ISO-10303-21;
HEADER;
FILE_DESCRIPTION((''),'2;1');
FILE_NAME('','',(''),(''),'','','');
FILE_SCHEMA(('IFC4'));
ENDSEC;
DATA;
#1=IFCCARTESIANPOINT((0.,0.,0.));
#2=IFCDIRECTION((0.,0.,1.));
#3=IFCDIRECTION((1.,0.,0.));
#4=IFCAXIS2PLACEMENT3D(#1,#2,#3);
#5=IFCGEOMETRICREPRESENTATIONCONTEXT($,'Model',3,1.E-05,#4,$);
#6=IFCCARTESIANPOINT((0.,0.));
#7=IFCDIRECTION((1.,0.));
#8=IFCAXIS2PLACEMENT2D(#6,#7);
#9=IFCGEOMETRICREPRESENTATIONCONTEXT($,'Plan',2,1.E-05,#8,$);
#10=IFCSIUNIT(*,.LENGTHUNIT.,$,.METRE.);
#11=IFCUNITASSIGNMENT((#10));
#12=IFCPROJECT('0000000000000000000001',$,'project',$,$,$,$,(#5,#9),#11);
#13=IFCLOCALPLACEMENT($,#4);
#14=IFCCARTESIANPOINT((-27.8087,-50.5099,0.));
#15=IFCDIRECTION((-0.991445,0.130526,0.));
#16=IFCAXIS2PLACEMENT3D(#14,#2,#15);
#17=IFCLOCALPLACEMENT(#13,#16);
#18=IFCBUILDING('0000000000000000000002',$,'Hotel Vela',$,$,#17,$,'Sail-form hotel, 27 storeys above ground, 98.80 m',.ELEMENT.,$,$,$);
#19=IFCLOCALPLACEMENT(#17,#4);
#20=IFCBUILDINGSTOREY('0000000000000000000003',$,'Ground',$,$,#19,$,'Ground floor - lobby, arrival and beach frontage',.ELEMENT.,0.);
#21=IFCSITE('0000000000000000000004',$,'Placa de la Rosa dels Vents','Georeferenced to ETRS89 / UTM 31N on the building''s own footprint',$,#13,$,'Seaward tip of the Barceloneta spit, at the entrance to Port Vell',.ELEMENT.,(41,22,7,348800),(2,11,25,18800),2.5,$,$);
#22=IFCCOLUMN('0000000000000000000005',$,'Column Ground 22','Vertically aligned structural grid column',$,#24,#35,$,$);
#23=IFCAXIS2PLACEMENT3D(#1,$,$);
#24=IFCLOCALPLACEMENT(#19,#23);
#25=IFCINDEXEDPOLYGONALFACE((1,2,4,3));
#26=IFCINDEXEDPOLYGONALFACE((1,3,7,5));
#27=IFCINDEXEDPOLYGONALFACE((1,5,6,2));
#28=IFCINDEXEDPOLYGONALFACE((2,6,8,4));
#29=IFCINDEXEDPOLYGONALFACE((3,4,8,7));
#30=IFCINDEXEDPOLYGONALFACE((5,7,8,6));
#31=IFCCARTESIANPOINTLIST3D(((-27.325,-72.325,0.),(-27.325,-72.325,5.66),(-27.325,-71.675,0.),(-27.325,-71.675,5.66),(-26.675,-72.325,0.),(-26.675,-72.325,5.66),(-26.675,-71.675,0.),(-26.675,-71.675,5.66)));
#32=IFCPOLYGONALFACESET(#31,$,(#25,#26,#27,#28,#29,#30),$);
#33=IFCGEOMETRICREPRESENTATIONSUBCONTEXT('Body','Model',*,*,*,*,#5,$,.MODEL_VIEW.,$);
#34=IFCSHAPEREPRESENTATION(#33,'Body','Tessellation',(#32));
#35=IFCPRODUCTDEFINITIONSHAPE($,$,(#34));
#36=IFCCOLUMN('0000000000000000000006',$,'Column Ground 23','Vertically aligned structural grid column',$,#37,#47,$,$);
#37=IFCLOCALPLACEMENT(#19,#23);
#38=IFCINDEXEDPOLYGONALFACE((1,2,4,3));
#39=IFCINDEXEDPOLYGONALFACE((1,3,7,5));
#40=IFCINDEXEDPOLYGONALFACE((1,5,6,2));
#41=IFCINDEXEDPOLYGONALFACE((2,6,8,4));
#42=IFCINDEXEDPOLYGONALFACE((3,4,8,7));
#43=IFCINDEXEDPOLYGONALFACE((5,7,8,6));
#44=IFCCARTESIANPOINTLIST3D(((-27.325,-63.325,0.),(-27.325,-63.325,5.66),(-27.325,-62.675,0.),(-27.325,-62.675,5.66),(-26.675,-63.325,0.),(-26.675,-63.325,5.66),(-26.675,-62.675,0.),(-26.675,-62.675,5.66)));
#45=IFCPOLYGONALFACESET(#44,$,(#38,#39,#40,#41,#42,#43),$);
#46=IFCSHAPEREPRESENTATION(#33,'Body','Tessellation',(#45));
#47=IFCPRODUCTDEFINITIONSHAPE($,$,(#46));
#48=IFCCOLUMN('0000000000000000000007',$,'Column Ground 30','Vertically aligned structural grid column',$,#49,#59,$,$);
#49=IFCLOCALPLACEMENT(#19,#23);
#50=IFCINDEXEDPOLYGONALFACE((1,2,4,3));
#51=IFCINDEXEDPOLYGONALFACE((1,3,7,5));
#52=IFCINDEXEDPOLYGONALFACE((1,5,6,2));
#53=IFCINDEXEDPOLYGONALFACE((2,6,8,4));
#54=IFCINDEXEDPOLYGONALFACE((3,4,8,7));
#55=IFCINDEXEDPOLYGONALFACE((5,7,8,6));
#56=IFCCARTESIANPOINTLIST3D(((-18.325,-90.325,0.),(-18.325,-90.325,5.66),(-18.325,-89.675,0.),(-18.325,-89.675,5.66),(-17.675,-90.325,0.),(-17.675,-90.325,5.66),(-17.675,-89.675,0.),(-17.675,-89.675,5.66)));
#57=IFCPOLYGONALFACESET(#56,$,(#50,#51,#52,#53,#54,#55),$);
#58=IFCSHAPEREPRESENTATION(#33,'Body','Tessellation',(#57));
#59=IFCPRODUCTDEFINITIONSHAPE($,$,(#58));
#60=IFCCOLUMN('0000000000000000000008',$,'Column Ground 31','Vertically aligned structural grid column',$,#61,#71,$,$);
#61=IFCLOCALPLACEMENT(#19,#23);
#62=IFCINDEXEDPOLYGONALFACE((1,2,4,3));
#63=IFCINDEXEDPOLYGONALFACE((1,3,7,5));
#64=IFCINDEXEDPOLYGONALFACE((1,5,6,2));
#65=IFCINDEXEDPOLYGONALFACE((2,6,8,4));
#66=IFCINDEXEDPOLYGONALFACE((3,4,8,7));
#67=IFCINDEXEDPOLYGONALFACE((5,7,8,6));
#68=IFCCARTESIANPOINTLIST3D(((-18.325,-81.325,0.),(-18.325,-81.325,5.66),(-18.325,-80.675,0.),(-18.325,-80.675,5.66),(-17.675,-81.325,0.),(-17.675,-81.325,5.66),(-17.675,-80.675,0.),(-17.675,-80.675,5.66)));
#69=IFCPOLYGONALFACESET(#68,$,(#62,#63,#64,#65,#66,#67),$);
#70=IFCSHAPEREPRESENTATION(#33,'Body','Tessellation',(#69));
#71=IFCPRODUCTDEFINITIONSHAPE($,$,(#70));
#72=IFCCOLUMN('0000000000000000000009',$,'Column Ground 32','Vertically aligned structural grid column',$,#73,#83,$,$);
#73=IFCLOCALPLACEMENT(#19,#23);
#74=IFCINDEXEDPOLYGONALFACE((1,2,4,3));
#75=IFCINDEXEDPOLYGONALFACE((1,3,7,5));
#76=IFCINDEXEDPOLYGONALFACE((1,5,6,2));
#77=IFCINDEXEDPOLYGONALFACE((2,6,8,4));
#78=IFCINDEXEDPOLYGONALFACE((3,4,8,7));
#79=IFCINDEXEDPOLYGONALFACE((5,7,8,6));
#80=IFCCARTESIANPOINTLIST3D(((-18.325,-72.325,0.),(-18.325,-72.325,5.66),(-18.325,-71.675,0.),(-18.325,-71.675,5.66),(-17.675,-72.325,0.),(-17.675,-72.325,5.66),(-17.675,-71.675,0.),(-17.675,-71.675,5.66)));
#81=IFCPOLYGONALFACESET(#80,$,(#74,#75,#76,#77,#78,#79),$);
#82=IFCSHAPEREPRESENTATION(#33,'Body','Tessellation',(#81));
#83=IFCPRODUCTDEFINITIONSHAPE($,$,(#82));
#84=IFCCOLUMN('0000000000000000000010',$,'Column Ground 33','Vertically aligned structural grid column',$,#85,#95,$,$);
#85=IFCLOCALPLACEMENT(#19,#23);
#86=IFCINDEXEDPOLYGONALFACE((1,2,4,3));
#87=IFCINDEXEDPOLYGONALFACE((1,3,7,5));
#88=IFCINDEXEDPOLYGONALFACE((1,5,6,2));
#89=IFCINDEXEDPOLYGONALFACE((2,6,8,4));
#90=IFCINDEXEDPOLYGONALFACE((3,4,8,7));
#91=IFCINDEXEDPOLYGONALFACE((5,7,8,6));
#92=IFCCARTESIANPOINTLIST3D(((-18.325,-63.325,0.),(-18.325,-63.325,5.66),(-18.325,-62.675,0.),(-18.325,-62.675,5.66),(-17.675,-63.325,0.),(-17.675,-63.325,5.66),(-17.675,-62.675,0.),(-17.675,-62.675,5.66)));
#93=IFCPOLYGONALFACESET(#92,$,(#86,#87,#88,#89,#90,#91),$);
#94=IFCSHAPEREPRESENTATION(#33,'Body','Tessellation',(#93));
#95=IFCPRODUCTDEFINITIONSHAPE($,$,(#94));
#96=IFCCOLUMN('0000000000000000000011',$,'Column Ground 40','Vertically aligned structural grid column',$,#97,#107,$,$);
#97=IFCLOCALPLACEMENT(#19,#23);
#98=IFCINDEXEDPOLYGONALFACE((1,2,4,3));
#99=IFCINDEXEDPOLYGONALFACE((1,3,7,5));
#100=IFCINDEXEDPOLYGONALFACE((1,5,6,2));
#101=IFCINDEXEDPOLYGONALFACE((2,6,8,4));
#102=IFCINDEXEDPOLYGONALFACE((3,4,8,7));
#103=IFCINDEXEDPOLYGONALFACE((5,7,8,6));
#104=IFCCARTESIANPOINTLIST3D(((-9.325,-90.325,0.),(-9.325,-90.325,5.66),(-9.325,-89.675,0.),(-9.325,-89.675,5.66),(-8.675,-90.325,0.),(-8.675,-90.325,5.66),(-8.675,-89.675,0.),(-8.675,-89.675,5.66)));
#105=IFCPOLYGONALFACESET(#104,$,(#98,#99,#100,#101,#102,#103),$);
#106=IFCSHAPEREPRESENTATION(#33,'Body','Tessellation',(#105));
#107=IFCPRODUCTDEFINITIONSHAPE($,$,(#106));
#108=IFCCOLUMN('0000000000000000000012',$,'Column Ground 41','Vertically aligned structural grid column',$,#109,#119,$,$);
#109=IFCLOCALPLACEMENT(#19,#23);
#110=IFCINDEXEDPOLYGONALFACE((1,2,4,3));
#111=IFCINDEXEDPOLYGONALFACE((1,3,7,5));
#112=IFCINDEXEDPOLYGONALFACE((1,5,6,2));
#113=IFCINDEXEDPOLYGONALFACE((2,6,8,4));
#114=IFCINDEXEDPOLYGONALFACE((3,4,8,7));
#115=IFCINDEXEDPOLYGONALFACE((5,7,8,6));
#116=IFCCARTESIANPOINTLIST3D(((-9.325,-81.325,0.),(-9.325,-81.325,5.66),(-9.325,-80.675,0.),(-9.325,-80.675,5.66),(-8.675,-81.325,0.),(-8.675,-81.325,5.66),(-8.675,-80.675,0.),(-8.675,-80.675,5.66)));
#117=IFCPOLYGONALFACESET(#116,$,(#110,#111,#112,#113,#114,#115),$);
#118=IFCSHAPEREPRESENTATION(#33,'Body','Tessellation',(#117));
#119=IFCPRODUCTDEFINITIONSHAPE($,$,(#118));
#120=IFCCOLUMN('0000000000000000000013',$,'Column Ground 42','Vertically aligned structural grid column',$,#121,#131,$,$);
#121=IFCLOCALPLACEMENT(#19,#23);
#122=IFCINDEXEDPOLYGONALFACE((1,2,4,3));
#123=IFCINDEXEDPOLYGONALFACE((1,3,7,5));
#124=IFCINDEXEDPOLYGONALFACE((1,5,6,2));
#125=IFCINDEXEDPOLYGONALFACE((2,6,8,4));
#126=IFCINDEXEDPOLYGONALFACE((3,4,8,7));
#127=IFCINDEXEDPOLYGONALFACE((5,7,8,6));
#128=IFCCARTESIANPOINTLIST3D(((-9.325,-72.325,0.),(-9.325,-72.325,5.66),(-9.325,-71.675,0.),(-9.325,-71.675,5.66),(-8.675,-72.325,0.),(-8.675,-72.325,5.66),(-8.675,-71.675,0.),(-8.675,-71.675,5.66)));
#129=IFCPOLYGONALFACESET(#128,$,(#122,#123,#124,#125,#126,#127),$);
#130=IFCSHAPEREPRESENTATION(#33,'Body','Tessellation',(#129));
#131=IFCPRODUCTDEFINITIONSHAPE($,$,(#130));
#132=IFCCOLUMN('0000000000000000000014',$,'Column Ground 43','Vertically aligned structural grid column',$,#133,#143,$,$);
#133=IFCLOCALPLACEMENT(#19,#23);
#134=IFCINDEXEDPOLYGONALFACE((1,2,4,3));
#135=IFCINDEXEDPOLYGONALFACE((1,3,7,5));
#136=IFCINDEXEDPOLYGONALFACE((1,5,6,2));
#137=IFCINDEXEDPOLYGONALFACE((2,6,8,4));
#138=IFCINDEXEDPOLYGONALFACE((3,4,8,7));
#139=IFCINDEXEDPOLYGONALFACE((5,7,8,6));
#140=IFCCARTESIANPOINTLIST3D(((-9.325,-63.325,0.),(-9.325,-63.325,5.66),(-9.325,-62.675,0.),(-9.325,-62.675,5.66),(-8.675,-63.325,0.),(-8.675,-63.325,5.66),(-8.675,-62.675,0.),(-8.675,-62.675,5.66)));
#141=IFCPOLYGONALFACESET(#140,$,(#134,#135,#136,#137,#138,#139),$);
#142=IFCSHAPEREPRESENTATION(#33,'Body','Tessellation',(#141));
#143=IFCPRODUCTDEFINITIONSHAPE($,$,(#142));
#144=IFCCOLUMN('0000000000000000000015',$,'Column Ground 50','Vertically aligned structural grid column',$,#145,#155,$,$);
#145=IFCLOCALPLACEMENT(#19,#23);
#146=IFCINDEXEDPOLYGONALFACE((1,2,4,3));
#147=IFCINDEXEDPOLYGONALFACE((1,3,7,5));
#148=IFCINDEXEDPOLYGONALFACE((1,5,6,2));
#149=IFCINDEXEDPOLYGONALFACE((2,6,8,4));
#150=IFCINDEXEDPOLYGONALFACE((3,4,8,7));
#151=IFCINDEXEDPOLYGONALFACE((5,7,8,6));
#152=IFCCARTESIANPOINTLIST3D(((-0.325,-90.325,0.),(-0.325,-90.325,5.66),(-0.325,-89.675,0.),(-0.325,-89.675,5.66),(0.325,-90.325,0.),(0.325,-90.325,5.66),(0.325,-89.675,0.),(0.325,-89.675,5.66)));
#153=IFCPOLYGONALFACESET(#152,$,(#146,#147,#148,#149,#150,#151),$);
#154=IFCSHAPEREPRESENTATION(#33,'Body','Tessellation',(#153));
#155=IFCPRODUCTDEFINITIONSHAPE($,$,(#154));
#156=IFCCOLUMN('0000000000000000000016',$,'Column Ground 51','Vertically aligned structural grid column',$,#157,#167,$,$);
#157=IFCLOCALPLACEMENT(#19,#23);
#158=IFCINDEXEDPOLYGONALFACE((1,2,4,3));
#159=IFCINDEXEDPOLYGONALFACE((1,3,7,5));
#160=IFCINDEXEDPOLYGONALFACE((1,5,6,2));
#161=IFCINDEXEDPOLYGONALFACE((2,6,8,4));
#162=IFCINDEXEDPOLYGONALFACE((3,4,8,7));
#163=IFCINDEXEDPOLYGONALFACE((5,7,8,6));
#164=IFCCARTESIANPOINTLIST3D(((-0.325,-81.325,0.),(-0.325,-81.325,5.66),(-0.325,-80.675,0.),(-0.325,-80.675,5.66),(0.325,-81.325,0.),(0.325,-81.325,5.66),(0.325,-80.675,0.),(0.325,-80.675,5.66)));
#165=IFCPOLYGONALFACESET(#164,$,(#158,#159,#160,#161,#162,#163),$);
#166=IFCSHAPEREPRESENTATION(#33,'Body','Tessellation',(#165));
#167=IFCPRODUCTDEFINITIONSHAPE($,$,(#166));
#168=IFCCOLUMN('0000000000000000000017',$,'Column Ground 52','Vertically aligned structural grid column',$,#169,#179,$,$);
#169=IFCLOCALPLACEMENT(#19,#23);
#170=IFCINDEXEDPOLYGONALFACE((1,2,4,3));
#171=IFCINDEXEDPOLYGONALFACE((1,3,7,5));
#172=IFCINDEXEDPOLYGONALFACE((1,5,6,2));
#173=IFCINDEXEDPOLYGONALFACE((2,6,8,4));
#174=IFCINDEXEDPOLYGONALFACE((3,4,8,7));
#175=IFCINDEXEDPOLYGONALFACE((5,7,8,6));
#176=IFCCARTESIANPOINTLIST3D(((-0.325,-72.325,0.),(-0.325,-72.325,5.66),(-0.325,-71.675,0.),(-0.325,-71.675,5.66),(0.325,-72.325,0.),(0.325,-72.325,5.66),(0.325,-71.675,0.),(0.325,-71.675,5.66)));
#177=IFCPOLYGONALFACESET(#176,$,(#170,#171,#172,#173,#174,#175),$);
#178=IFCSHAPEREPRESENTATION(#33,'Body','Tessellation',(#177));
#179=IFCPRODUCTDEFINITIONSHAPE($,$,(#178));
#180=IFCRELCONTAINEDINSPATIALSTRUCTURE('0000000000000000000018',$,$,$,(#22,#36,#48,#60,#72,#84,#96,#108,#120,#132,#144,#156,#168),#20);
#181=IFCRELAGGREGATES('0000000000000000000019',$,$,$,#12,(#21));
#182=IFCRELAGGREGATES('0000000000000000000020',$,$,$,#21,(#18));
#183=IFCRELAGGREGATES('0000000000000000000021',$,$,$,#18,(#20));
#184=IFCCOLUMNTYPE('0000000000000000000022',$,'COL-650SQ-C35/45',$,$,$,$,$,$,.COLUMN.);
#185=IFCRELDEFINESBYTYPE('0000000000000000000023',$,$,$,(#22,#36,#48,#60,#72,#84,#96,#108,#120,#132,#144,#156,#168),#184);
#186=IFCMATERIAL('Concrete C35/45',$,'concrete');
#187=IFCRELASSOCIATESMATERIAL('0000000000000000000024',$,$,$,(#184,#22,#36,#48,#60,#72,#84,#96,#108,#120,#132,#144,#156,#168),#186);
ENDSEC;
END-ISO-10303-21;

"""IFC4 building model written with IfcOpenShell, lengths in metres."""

from ifc_helpers import new_model, si_unit, frame, origin_with_axes, origin_2d_with_axis, place, context, subcontext, project, spatial, line, indexed_curve, rectangle, outline, extrude, material, material_profile, profile_set, profile_usage, type_object, element, save


model = new_model("IFC4")

# Units and contexts
model_context = context("Model", 3, precision=1e-05, world=origin_with_axes())
plan_context = context("Plan", 2, precision=1e-05, world=origin_2d_with_axis())
body_context = subcontext(model_context, "Body", "Model", "MODEL_VIEW")
ifc_project = project(units=[si_unit("LENGTHUNIT", "METRE")], contexts=[model_context, plan_context])

# Site, building, storey
site_placement = place(None, origin_with_axes())
site = spatial("IfcSite", under=ifc_project, at=site_placement, Name="Placa de la Rosa dels Vents", Description="Georeferenced to ETRS89 / UTM 31N on the building's own footprint", LongName="Seaward tip of the Barceloneta spit, at the entrance to Port Vell", CompositionType="ELEMENT", RefLatitude=(41, 22, 7, 348800), RefLongitude=(2, 11, 25, 18800), RefElevation=2.5)
building_placement = place(site_placement, frame((-27.8087, -50.5099, 0.0), z_axis=(0.0, 0.0, 1.0), x_axis=(-0.991445, 0.130526, 0.0)))
building = spatial("IfcBuilding", under=site, at=building_placement, Name="Hotel Vela", LongName="Sail-form hotel, 27 storeys above ground, 98.80 m", CompositionType="ELEMENT")
storey_placement = place(building_placement, origin_with_axes())
storey = spatial("IfcBuildingStorey", under=building, at=storey_placement, Name="Ground", LongName="Ground floor - lobby, arrival and beach frontage", CompositionType="ELEMENT", Elevation=0.0)

# Columns
ifc_material = material(Name="Concrete C35/45", Category="concrete")
ifc_material_profile = material_profile(ifc_material, rectangle(XDim=0.65, YDim=0.65))
ifc_profile_set = profile_set([ifc_material_profile], Name="COL-650SQ-C35/45")
column_type = type_object("IfcColumnType", Name="COL-650SQ-C35/45", PredefinedType="COLUMN", material=ifc_profile_set)
ifc_profile_usage_1 = profile_usage(ifc_profile_set)
column_1_placement = place(storey_placement, frame((-27.325, -72.325, 0.0), z_axis=(0.0, 0.0, 1.0), x_axis=(1.0, 0.0, 0.0)))
element("IfcColumn", 1, at=column_1_placement, inside=storey, type_object=column_type, material=ifc_profile_usage_1, Name="Column Ground 22", Description="Vertically aligned structural grid column", context=body_context, shape_type="SweptSolid", body=[
    extrude(outline(indexed_curve([(0.0, 0.0), (0.65, 0.0), (0.65, 0.65), (0.0, 0.65)], segments=[line(1, 2, 3, 4, 1)])), origin_with_axes(), (0.0, 0.0, 1.0), 5.66),
])
ifc_profile_usage_2 = profile_usage(ifc_profile_set)
column_2_placement = place(storey_placement, frame((-27.325, -63.325, 0.0), z_axis=(0.0, 0.0, 1.0), x_axis=(1.0, 0.0, 0.0)))
element("IfcColumn", 2, at=column_2_placement, inside=storey, type_object=column_type, material=ifc_profile_usage_2, Name="Column Ground 23", Description="Vertically aligned structural grid column", context=body_context, shape_type="SweptSolid", body=[
    extrude(outline(indexed_curve([(0.0, 0.0), (0.65, 0.0), (0.65, 0.65), (0.0, 0.65)], segments=[line(1, 2, 3, 4, 1)])), origin_with_axes(), (0.0, 0.0, 1.0), 5.66),
])
ifc_profile_usage_3 = profile_usage(ifc_profile_set)
column_3_placement = place(storey_placement, frame((-18.325, -90.325, 0.0), z_axis=(0.0, 0.0, 1.0), x_axis=(1.0, 0.0, 0.0)))
element("IfcColumn", 3, at=column_3_placement, inside=storey, type_object=column_type, material=ifc_profile_usage_3, Name="Column Ground 30", Description="Vertically aligned structural grid column", context=body_context, shape_type="SweptSolid", body=[
    extrude(outline(indexed_curve([(0.0, 0.0), (0.65, 0.0), (0.65, 0.65), (0.0, 0.65)], segments=[line(1, 2, 3, 4, 1)])), origin_with_axes(), (0.0, 0.0, 1.0), 5.66),
])
ifc_profile_usage_4 = profile_usage(ifc_profile_set)
column_4_placement = place(storey_placement, frame((-18.325, -81.325, 0.0), z_axis=(0.0, 0.0, 1.0), x_axis=(1.0, 0.0, 0.0)))
element("IfcColumn", 4, at=column_4_placement, inside=storey, type_object=column_type, material=ifc_profile_usage_4, Name="Column Ground 31", Description="Vertically aligned structural grid column", context=body_context, shape_type="SweptSolid", body=[
    extrude(outline(indexed_curve([(0.0, 0.0), (0.65, 0.0), (0.65, 0.65), (0.0, 0.65)], segments=[line(1, 2, 3, 4, 1)])), origin_with_axes(), (0.0, 0.0, 1.0), 5.66),
])
ifc_profile_usage_5 = profile_usage(ifc_profile_set)
column_5_placement = place(storey_placement, frame((-18.325, -72.325, 0.0), z_axis=(0.0, 0.0, 1.0), x_axis=(1.0, 0.0, 0.0)))
element("IfcColumn", 5, at=column_5_placement, inside=storey, type_object=column_type, material=ifc_profile_usage_5, Name="Column Ground 32", Description="Vertically aligned structural grid column", context=body_context, shape_type="SweptSolid", body=[
    extrude(outline(indexed_curve([(0.0, 0.0), (0.65, 0.0), (0.65, 0.65), (0.0, 0.65)], segments=[line(1, 2, 3, 4, 1)])), origin_with_axes(), (0.0, 0.0, 1.0), 5.66),
])
ifc_profile_usage_6 = profile_usage(ifc_profile_set)
column_6_placement = place(storey_placement, frame((-18.325, -63.325, 0.0), z_axis=(0.0, 0.0, 1.0), x_axis=(1.0, 0.0, 0.0)))
element("IfcColumn", 6, at=column_6_placement, inside=storey, type_object=column_type, material=ifc_profile_usage_6, Name="Column Ground 33", Description="Vertically aligned structural grid column", context=body_context, shape_type="SweptSolid", body=[
    extrude(outline(indexed_curve([(0.0, 0.0), (0.65, 0.0), (0.65, 0.65), (0.0, 0.65)], segments=[line(1, 2, 3, 4, 1)])), origin_with_axes(), (0.0, 0.0, 1.0), 5.66),
])
ifc_profile_usage_7 = profile_usage(ifc_profile_set)
column_7_placement = place(storey_placement, frame((-9.325, -90.325, 0.0), z_axis=(0.0, 0.0, 1.0), x_axis=(1.0, 0.0, 0.0)))
element("IfcColumn", 7, at=column_7_placement, inside=storey, type_object=column_type, material=ifc_profile_usage_7, Name="Column Ground 40", Description="Vertically aligned structural grid column", context=body_context, shape_type="SweptSolid", body=[
    extrude(outline(indexed_curve([(0.0, 0.0), (0.65, 0.0), (0.65, 0.65), (0.0, 0.65)], segments=[line(1, 2, 3, 4, 1)])), origin_with_axes(), (0.0, 0.0, 1.0), 5.66),
])
ifc_profile_usage_8 = profile_usage(ifc_profile_set)
column_8_placement = place(storey_placement, frame((-9.325, -81.325, 0.0), z_axis=(0.0, 0.0, 1.0), x_axis=(1.0, 0.0, 0.0)))
element("IfcColumn", 8, at=column_8_placement, inside=storey, type_object=column_type, material=ifc_profile_usage_8, Name="Column Ground 41", Description="Vertically aligned structural grid column", context=body_context, shape_type="SweptSolid", body=[
    extrude(outline(indexed_curve([(0.0, 0.0), (0.65, 0.0), (0.65, 0.65), (0.0, 0.65)], segments=[line(1, 2, 3, 4, 1)])), origin_with_axes(), (0.0, 0.0, 1.0), 5.66),
])
ifc_profile_usage_9 = profile_usage(ifc_profile_set)
column_9_placement = place(storey_placement, frame((-9.325, -72.325, 0.0), z_axis=(0.0, 0.0, 1.0), x_axis=(1.0, 0.0, 0.0)))
element("IfcColumn", 9, at=column_9_placement, inside=storey, type_object=column_type, material=ifc_profile_usage_9, Name="Column Ground 42", Description="Vertically aligned structural grid column", context=body_context, shape_type="SweptSolid", body=[
    extrude(outline(indexed_curve([(0.0, 0.0), (0.65, 0.0), (0.65, 0.65), (0.0, 0.65)], segments=[line(1, 2, 3, 4, 1)])), origin_with_axes(), (0.0, 0.0, 1.0), 5.66),
])
ifc_profile_usage_10 = profile_usage(ifc_profile_set)
column_10_placement = place(storey_placement, frame((-9.325, -63.325, 0.0), z_axis=(0.0, 0.0, 1.0), x_axis=(1.0, 0.0, 0.0)))
element("IfcColumn", 10, at=column_10_placement, inside=storey, type_object=column_type, material=ifc_profile_usage_10, Name="Column Ground 43", Description="Vertically aligned structural grid column", context=body_context, shape_type="SweptSolid", body=[
    extrude(outline(indexed_curve([(0.0, 0.0), (0.65, 0.0), (0.65, 0.65), (0.0, 0.65)], segments=[line(1, 2, 3, 4, 1)])), origin_with_axes(), (0.0, 0.0, 1.0), 5.66),
])
ifc_profile_usage_11 = profile_usage(ifc_profile_set)
column_11_placement = place(storey_placement, frame((-0.325, -90.325, 0.0), z_axis=(0.0, 0.0, 1.0), x_axis=(1.0, 0.0, 0.0)))
element("IfcColumn", 11, at=column_11_placement, inside=storey, type_object=column_type, material=ifc_profile_usage_11, Name="Column Ground 50", Description="Vertically aligned structural grid column", context=body_context, shape_type="SweptSolid", body=[
    extrude(outline(indexed_curve([(0.0, 0.0), (0.65, 0.0), (0.65, 0.65), (0.0, 0.65)], segments=[line(1, 2, 3, 4, 1)])), origin_with_axes(), (0.0, 0.0, 1.0), 5.66),
])
ifc_profile_usage_12 = profile_usage(ifc_profile_set)
column_12_placement = place(storey_placement, frame((-0.325, -81.325, 0.0), z_axis=(0.0, 0.0, 1.0), x_axis=(1.0, 0.0, 0.0)))
element("IfcColumn", 12, at=column_12_placement, inside=storey, type_object=column_type, material=ifc_profile_usage_12, Name="Column Ground 51", Description="Vertically aligned structural grid column", context=body_context, shape_type="SweptSolid", body=[
    extrude(outline(indexed_curve([(0.0, 0.0), (0.65, 0.0), (0.65, 0.65), (0.0, 0.65)], segments=[line(1, 2, 3, 4, 1)])), origin_with_axes(), (0.0, 0.0, 1.0), 5.66),
])
ifc_profile_usage_13 = profile_usage(ifc_profile_set)
column_13_placement = place(storey_placement, frame((-0.325, -72.325, 0.0), z_axis=(0.0, 0.0, 1.0), x_axis=(1.0, 0.0, 0.0)))
element("IfcColumn", 13, at=column_13_placement, inside=storey, type_object=column_type, material=ifc_profile_usage_13, Name="Column Ground 52", Description="Vertically aligned structural grid column", context=body_context, shape_type="SweptSolid", body=[
    extrude(outline(indexed_curve([(0.0, 0.0), (0.65, 0.0), (0.65, 0.65), (0.0, 0.65)], segments=[line(1, 2, 3, 4, 1)])), origin_with_axes(), (0.0, 0.0, 1.0), 5.66),
])

save(model, "model.ifc")
